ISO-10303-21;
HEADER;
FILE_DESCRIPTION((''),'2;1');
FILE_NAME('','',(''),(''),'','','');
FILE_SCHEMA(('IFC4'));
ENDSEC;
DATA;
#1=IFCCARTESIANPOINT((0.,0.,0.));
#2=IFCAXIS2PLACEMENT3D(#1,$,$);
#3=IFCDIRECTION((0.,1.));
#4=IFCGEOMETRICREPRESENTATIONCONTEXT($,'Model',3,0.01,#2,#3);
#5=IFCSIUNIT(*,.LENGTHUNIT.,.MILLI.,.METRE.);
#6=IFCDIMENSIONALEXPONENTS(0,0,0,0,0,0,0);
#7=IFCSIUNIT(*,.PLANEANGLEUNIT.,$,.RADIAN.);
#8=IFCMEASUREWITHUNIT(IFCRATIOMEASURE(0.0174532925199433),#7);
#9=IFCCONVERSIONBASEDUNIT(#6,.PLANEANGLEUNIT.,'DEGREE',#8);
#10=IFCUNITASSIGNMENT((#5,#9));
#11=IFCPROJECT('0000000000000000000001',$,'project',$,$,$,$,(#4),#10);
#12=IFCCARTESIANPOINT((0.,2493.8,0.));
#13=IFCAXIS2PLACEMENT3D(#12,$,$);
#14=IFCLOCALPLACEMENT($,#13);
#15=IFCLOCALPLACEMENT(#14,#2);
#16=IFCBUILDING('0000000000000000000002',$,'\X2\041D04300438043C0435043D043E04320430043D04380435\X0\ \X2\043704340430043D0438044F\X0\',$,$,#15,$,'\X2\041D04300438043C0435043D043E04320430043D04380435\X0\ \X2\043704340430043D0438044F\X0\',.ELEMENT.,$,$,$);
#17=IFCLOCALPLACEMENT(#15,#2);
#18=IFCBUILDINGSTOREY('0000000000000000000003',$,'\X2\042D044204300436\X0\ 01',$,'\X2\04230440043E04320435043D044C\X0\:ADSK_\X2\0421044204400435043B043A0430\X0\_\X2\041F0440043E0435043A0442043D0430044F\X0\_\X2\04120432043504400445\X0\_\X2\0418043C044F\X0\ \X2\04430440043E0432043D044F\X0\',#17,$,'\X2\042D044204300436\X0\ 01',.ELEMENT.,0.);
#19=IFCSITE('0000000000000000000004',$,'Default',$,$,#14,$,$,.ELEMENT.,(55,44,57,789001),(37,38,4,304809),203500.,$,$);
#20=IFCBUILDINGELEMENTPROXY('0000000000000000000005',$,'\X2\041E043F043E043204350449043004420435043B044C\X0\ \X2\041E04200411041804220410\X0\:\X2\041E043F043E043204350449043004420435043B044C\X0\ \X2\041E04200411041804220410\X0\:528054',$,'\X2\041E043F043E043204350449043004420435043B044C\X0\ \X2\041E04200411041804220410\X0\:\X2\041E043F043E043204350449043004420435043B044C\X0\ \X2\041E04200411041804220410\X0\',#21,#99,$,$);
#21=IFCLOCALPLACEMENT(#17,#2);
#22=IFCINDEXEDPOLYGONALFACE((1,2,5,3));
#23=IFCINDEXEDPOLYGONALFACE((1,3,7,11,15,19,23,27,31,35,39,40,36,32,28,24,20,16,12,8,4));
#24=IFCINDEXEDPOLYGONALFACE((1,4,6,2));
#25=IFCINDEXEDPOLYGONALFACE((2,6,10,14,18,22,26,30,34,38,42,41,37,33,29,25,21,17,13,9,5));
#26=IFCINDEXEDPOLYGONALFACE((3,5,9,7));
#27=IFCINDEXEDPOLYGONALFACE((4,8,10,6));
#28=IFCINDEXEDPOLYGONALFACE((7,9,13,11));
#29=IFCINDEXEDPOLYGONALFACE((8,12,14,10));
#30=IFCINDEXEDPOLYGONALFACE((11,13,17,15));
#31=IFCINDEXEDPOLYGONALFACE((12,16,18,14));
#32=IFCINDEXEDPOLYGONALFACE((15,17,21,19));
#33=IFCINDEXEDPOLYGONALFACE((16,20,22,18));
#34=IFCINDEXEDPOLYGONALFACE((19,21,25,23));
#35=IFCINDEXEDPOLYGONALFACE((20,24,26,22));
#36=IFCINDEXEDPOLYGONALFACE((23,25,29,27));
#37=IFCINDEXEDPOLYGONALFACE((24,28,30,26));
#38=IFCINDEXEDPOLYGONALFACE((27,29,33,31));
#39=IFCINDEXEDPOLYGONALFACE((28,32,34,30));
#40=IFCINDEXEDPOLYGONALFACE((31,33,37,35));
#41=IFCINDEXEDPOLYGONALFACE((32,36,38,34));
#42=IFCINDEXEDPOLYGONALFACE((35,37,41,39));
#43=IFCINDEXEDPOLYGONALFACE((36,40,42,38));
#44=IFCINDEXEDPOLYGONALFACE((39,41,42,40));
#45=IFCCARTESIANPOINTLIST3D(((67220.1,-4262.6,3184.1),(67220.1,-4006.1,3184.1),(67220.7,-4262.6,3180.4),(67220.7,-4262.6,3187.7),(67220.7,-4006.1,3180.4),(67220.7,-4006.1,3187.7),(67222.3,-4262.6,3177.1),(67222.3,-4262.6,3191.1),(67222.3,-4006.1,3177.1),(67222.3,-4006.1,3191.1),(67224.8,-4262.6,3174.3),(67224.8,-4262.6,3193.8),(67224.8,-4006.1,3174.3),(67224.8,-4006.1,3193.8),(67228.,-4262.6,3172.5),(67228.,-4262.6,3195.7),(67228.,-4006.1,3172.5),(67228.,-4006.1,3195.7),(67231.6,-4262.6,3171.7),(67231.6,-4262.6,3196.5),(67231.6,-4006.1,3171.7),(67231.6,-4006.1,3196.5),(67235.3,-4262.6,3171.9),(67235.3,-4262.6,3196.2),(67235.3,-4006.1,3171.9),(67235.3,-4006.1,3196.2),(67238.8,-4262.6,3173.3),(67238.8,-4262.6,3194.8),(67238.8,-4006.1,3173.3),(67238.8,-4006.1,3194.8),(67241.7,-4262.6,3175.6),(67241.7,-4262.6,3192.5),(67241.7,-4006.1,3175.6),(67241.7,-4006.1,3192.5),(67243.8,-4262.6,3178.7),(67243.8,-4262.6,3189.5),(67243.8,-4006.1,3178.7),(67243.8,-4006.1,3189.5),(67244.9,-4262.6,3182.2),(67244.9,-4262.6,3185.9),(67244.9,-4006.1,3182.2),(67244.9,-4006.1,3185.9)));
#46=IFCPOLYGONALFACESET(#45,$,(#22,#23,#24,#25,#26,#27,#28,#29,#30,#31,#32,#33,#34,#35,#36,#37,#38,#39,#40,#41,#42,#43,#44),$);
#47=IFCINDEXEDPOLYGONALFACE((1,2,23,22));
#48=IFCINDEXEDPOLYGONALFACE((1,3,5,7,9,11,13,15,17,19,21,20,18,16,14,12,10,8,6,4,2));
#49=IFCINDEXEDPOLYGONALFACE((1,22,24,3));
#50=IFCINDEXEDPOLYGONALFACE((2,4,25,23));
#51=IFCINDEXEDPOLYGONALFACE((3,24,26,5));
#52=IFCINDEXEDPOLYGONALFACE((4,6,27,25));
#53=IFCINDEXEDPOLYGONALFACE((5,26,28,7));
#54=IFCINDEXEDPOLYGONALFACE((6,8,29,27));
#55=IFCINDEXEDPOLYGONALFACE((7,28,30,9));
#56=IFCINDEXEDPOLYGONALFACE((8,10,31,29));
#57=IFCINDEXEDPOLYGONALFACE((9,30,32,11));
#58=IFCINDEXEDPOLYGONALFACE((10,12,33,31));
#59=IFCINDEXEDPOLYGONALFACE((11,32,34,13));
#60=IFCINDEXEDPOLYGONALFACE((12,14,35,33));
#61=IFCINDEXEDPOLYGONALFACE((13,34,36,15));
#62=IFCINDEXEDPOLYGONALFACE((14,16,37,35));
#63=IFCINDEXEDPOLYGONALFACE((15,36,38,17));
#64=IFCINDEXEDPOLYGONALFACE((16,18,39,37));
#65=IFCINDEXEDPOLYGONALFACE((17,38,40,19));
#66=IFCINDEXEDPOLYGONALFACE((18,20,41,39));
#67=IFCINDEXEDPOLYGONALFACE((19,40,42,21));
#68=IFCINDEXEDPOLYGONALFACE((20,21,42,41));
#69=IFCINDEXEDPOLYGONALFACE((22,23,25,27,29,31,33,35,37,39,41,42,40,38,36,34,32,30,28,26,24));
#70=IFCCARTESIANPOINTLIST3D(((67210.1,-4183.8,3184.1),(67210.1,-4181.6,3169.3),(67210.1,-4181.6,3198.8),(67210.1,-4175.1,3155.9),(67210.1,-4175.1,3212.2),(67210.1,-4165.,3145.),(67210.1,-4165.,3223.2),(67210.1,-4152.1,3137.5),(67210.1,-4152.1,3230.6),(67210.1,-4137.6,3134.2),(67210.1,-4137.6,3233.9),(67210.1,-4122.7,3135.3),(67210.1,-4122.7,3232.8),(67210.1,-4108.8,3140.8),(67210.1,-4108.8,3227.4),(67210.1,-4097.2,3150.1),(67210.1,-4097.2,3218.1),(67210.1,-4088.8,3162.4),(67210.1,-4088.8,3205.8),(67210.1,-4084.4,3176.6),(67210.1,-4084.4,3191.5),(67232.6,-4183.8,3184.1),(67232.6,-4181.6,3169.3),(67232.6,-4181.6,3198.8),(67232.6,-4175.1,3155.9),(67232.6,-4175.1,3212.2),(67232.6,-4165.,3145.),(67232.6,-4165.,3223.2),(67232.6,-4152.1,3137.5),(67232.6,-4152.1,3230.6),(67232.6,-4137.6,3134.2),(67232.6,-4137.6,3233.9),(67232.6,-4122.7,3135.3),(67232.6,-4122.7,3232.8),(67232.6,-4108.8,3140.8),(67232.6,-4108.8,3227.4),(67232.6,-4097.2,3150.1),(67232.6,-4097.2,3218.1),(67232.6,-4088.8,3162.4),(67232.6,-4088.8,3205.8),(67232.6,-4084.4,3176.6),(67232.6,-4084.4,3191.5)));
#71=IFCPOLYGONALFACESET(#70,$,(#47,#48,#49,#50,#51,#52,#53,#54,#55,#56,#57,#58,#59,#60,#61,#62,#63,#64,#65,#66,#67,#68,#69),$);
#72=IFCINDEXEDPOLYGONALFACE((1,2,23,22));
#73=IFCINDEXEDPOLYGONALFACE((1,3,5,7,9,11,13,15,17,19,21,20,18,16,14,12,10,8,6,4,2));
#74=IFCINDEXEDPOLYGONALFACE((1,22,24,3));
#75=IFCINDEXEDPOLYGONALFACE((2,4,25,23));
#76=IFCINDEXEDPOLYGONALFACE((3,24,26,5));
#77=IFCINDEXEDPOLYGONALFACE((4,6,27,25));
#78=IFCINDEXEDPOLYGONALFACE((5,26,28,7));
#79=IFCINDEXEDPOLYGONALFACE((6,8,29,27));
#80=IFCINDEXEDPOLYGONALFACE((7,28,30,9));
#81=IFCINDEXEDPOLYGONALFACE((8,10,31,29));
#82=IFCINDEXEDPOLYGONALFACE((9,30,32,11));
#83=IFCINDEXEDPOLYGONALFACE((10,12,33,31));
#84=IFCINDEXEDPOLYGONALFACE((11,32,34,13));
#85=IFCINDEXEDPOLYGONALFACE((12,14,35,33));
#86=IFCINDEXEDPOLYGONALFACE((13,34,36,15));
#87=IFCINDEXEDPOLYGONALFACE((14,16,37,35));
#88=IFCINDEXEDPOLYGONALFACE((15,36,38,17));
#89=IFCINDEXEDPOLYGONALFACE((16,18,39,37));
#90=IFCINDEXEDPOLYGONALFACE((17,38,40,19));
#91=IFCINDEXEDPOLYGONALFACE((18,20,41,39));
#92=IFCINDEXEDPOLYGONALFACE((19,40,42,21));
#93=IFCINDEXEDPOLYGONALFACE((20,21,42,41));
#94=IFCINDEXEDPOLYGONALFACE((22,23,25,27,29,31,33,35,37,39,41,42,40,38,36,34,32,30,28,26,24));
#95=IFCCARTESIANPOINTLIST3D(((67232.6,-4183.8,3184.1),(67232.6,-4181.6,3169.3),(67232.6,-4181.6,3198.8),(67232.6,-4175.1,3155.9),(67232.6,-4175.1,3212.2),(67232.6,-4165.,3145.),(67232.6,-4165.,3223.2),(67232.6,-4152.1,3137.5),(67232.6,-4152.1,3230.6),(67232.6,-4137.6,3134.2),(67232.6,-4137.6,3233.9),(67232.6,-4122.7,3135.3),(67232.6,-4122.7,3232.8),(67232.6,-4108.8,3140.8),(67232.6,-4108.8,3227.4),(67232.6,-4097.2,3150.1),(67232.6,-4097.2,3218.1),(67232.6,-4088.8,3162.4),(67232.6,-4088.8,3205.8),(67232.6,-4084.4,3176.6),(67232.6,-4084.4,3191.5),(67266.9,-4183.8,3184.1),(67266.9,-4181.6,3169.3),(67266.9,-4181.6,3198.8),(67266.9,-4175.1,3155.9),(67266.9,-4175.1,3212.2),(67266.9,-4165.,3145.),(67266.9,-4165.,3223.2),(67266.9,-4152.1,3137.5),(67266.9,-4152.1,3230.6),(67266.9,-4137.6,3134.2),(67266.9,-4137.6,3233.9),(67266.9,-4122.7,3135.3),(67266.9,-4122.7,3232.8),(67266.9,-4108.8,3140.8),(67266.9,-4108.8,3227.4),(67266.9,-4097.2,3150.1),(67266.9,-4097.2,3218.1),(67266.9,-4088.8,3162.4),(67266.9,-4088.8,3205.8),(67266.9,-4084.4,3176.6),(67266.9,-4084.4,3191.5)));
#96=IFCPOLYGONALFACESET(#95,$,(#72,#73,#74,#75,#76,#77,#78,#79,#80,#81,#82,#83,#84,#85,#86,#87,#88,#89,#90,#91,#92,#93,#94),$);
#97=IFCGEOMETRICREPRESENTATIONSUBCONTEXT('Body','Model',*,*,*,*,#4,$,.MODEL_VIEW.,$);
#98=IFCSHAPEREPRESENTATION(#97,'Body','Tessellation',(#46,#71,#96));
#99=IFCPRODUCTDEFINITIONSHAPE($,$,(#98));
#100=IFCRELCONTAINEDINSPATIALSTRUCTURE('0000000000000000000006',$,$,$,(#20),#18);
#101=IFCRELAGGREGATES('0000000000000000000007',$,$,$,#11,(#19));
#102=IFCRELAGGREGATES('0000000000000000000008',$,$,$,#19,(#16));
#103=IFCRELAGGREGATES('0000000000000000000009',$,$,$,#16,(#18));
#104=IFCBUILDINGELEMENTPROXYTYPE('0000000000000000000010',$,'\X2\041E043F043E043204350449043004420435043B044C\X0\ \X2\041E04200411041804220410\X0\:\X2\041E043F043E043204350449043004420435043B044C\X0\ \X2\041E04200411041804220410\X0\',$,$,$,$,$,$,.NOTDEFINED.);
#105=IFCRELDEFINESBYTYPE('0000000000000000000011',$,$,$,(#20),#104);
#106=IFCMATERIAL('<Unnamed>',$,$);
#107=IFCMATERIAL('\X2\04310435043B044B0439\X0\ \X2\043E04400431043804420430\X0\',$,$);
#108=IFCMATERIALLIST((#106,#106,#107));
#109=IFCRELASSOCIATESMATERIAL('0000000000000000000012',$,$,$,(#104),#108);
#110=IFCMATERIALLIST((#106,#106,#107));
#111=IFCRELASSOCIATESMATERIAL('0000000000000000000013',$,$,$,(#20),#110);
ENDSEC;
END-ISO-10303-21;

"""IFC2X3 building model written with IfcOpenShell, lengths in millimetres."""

from ifc_helpers import new_model, entity, si_unit, converted_unit, direction, frame, frame_2d, origin, origin_2d_with_axis, place, context, subcontext, project, spatial, circle, extrude, source, transform, mapped, material, material_list, type_object, type_shapes, element, save


model = new_model("IFC2X3")

# Units and contexts
model_context = context("Model", 3, precision=0.01, world=origin(), true_north=direction((0.0, 1.0)))
body_context = subcontext(model_context, "Body", "Model", "MODEL_VIEW")
ifc_project = project(units=[si_unit("LENGTHUNIT", "METRE", prefix="MILLI"), converted_unit("PLANEANGLEUNIT", "DEGREE", entity("IfcRatioMeasure", 0.0174532925199433), si_unit("PLANEANGLEUNIT", "RADIAN"), dimensions=[0, 0, 0, 0, 0, 0, 0])], contexts=[model_context])

# Site, building, storey
site_placement = place(None, frame((0.0, 2493.8, 0.0)))
site = spatial("IfcSite", under=ifc_project, at=site_placement, Name="Default", CompositionType="ELEMENT", RefLatitude=(55, 44, 57, 789001), RefLongitude=(37, 38, 4, 304809), RefElevation=203500.0)
building_placement = place(site_placement, origin())
building = spatial("IfcBuilding", under=site, at=building_placement, Name="Наименование здания", LongName="Наименование здания", CompositionType="ELEMENT")
storey_placement = place(building_placement, origin())
storey = spatial("IfcBuildingStorey", under=building, at=storey_placement, Name="Этаж 01", ObjectType="Уровень:ADSK_Стрелка_Проектная_Вверх_Имя уровня", LongName="Этаж 01", CompositionType="ELEMENT", Elevation=0.0)

# Building element proxy
ifc_material_1 = material(Name="<Unnamed>")
ifc_material_2 = material(Name="белый орбита")
ifc_material_list_1 = material_list([ifc_material_1, ifc_material_1, ifc_material_2])
ifc_material_list_2 = material_list([ifc_material_1, ifc_material_1, ifc_material_2])
building_element_proxy_type_1 = type_object("IfcBuildingElementProxyType", Name="Оповещатель ОРБИТА:Оповещатель ОРБИТА", PredefinedType="NOTDEFINED", material=ifc_material_list_2)
shared_shape_1 = source(origin(), body_context, "Body", "SweptSolid", [
    extrude(circle(Radius=12.4, at=frame_2d((0.0, 0.0), x_axis=(1.0, 0.0))), frame((22.5, 0.0, 51.6), z_axis=(0.0, 1.0, 0.0), x_axis=(-1.0, 0.0, 0.0)), (0.0, 0.0, 1.0), 256.5),
    extrude(circle(Radius=50.0, at=origin_2d_with_axis()), frame((0.0, 128.8, 51.6), z_axis=(1.0, 0.0, 0.0), x_axis=(0.0, -1.0, 0.0)), (0.0, 0.0, 1.0), 22.5),
    extrude(circle(Radius=50.0, at=frame_2d((0.0, 0.0), x_axis=(1.0, 0.0))), frame((22.5, 128.8, 51.6), z_axis=(1.0, 0.0, 0.0), x_axis=(0.0, -1.0, 0.0)), (0.0, 0.0, 1.0), 34.3),
])
type_shapes(building_element_proxy_type_1, [shared_shape_1])
proxy_1_placement = place(storey_placement, frame((67210.1, -4262.6, 3132.5)))
element("IfcBuildingElementProxy", 1, at=proxy_1_placement, inside=storey, type_object=building_element_proxy_type_1, material=ifc_material_list_1, Name="Оповещатель ОРБИТА:Оповещатель ОРБИТА:528054", ObjectType="Оповещатель ОРБИТА:Оповещатель ОРБИТА", context=body_context, shape_type="MappedRepresentation", body=[
    mapped(shared_shape_1, transform((0.0, 0.0, 0.0), scale=1.0)),
])

save(model, "model.ifc")
